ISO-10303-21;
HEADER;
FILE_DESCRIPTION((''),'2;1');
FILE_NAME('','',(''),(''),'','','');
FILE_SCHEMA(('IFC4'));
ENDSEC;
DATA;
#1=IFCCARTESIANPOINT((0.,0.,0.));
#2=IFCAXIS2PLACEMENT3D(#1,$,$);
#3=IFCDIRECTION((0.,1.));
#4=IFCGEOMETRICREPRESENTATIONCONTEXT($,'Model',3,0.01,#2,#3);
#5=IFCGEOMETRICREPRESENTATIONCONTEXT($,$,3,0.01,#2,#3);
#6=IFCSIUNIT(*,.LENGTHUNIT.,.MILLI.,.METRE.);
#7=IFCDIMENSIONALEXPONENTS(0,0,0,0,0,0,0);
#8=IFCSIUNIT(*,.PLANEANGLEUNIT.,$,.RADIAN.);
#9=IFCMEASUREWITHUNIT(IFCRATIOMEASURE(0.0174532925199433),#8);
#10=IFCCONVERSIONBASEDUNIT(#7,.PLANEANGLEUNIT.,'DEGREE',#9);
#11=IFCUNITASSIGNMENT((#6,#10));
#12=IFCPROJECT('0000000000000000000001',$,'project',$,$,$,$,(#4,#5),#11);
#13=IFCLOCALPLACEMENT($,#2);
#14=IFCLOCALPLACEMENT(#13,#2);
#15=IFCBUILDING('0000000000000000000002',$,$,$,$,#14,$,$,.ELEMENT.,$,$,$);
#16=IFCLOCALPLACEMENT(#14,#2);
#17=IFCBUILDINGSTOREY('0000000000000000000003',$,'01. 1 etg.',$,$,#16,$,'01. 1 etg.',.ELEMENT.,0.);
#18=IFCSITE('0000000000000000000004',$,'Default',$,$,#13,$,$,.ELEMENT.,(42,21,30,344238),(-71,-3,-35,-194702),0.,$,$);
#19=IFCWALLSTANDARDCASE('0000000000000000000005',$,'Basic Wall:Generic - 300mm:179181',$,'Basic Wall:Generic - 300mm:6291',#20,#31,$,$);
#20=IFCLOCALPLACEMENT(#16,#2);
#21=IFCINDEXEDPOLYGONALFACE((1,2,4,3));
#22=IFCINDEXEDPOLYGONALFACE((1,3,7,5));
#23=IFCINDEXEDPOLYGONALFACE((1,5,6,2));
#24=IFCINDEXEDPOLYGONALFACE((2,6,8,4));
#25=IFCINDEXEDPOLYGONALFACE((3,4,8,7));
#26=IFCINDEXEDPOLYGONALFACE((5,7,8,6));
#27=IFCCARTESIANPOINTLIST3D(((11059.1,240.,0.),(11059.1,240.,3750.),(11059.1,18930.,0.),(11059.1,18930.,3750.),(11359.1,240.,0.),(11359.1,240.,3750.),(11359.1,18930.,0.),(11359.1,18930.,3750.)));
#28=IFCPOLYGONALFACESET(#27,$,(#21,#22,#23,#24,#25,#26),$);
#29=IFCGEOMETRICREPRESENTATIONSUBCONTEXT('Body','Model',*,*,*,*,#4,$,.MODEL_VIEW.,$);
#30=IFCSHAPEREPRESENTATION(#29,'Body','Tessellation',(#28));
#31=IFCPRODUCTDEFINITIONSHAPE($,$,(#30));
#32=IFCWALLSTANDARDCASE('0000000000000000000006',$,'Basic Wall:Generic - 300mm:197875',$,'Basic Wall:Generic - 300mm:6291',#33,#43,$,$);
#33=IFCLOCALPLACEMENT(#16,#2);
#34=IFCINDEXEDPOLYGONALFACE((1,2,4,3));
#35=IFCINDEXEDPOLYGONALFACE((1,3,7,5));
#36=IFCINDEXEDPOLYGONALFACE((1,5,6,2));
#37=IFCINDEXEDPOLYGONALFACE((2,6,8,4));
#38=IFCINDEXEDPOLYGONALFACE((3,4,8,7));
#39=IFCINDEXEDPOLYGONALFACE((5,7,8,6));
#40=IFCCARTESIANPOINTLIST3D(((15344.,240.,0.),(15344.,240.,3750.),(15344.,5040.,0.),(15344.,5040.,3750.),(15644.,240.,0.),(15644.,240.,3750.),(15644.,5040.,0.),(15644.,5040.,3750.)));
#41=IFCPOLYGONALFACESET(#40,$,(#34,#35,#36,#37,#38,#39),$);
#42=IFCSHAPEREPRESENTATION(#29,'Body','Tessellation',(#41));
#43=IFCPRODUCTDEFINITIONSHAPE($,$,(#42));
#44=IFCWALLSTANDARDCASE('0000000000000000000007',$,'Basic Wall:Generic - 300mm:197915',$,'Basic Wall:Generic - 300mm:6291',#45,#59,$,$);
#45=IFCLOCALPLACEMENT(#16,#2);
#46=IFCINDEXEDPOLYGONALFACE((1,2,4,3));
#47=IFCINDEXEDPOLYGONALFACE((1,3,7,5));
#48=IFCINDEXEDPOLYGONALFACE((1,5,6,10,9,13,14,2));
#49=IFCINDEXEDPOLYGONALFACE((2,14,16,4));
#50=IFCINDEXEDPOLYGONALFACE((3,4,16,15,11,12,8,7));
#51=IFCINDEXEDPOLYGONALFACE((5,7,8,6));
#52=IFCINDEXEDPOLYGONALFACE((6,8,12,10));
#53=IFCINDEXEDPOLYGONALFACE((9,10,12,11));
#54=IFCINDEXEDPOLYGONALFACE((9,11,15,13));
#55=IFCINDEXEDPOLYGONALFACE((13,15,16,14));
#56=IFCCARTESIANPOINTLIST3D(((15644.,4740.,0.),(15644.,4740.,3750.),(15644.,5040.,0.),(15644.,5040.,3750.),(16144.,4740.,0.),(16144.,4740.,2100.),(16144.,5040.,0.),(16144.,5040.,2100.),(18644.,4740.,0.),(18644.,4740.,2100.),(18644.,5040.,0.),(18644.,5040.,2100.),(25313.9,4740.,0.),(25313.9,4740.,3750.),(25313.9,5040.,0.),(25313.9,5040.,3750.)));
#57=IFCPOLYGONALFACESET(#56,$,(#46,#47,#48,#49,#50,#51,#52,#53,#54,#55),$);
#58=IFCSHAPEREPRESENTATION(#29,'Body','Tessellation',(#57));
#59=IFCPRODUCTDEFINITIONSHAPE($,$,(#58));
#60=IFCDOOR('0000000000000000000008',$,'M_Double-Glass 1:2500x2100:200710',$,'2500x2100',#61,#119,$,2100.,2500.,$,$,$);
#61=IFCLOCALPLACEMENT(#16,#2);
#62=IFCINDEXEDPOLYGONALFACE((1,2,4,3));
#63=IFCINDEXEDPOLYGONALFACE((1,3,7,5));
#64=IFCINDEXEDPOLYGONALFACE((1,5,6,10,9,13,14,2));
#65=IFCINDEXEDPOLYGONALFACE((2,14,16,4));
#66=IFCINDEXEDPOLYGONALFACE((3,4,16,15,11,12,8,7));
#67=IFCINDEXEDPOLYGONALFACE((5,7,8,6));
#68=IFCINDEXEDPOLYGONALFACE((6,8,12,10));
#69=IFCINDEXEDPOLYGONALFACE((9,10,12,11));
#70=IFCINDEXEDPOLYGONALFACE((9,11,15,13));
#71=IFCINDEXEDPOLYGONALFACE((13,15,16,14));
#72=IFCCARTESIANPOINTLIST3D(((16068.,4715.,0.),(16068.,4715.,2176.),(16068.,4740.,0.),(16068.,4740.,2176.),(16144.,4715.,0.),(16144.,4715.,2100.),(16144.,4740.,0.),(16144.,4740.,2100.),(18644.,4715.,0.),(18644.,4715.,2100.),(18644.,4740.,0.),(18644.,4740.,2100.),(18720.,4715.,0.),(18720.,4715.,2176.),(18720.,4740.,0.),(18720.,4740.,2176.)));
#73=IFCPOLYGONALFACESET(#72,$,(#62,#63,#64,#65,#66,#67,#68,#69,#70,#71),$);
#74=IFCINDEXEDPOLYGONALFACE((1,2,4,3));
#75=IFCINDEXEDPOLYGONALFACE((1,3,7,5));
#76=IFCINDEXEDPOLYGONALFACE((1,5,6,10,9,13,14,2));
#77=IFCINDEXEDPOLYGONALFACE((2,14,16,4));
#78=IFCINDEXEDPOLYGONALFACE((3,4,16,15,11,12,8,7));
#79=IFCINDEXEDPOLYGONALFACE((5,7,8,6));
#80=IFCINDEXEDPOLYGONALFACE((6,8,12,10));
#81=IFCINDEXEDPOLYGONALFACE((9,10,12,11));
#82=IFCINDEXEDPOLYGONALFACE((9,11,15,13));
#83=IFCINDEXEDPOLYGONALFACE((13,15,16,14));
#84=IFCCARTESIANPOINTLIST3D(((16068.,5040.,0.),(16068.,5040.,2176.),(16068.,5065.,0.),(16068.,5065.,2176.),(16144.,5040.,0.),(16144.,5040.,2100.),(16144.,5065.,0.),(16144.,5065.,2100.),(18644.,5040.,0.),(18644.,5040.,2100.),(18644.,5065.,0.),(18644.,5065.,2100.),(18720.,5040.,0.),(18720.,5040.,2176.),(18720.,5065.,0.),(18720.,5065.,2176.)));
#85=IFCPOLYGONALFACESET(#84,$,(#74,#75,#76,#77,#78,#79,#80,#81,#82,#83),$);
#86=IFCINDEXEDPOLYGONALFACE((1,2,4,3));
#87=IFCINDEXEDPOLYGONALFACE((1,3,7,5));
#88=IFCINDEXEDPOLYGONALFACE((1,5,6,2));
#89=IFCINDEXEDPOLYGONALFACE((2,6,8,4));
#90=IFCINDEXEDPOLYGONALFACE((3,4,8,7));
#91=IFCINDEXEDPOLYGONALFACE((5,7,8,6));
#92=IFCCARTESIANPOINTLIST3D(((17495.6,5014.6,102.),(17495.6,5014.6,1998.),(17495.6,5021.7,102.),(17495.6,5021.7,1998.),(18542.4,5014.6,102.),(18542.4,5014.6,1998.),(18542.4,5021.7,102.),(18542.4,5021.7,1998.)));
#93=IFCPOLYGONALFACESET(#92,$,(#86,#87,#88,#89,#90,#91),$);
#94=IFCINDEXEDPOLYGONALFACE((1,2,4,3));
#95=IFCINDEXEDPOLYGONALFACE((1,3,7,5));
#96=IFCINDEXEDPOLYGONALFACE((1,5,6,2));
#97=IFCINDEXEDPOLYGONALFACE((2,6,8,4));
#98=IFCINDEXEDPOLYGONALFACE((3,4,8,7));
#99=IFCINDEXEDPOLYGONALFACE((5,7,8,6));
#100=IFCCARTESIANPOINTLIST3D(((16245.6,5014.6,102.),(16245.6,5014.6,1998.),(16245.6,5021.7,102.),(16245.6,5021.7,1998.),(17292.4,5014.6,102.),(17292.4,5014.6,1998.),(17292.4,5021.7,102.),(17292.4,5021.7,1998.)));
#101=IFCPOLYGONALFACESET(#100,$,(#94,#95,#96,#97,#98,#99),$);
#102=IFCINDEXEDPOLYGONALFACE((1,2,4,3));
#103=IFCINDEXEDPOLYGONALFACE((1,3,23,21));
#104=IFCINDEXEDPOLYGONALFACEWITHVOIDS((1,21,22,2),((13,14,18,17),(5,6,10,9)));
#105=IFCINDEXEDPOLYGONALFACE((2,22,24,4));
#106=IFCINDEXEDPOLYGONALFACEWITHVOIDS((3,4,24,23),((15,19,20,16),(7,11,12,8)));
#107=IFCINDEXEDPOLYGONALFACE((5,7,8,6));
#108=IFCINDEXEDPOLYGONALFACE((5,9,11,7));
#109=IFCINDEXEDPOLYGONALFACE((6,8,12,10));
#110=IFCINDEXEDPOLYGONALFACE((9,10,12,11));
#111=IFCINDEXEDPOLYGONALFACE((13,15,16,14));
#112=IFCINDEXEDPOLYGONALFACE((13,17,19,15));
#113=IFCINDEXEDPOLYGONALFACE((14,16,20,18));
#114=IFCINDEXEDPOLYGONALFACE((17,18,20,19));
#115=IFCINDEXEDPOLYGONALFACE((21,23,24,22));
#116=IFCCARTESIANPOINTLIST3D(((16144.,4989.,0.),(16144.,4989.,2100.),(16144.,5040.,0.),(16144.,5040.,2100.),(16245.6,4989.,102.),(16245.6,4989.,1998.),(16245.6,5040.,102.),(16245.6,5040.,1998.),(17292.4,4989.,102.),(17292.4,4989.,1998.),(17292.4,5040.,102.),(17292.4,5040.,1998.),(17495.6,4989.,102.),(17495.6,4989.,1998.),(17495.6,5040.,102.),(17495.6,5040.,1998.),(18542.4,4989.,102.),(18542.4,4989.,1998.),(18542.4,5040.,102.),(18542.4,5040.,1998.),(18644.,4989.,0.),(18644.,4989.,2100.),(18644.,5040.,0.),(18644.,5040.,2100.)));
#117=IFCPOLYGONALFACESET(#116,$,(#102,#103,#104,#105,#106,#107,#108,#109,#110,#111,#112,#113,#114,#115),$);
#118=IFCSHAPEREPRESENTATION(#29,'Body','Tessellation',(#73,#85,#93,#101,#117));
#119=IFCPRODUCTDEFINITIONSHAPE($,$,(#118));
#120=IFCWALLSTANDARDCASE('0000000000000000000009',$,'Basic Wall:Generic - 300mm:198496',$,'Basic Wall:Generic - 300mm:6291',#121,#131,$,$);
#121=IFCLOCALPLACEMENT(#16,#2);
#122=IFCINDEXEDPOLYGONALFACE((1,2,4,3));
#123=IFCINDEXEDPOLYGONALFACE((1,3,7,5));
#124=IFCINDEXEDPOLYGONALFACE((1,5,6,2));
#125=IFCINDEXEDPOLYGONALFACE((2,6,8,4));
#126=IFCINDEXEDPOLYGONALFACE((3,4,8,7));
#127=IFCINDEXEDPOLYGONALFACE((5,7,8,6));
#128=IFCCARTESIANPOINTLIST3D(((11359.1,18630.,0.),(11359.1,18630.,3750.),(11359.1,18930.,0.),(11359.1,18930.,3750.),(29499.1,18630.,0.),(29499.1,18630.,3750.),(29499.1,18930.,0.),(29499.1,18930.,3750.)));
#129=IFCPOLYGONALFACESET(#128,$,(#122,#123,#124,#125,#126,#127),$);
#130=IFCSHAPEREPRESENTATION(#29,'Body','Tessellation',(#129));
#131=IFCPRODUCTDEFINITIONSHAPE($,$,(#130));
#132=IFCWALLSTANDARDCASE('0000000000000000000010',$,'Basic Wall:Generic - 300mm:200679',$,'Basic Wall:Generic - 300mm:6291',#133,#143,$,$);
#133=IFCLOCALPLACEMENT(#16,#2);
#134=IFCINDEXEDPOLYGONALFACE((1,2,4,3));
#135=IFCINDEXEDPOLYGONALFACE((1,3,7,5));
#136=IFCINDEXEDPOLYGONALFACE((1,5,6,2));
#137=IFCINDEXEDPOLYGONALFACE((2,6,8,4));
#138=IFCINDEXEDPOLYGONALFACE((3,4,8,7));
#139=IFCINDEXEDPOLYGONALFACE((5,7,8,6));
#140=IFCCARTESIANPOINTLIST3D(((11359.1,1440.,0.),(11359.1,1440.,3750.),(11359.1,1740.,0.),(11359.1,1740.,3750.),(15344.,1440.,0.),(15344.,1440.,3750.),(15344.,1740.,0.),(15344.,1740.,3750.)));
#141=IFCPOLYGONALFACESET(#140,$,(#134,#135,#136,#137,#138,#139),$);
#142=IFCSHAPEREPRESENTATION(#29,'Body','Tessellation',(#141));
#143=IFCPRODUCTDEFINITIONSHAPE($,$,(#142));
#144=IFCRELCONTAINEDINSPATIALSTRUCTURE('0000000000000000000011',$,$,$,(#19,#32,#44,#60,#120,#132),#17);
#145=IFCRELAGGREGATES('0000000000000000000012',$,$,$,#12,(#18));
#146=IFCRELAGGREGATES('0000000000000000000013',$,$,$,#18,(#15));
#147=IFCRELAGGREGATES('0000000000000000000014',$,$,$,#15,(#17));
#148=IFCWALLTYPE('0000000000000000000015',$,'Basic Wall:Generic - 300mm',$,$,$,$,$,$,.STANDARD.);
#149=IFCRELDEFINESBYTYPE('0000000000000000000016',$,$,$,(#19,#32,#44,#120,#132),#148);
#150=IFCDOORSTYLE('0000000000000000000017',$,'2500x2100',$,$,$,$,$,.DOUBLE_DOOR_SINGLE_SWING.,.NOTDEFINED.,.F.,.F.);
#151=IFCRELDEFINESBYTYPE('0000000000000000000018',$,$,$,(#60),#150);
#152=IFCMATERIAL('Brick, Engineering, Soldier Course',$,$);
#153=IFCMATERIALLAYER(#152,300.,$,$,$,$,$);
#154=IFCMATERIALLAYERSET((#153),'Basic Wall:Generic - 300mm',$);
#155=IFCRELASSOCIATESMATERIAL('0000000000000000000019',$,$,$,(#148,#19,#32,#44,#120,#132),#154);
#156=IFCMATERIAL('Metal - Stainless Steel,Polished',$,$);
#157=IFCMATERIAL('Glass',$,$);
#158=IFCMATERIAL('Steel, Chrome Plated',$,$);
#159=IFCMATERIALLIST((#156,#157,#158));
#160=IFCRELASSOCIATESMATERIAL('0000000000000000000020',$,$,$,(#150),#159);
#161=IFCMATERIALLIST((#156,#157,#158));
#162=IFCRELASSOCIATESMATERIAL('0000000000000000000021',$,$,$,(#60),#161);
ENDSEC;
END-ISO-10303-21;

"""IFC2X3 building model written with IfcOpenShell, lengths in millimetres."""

from ifc_helpers import new_model, entity, si_unit, converted_unit, direction, frame, frame_2d, origin, place, context, subcontext, project, spatial, polyline, rectangle, outline, extrude, clip, halfspace, source, transform, mapped, material, material_list, layer, layer_set, layer_usage, type_object, type_shapes, element, fill, save


model = new_model("IFC2X3")

# Units and contexts
model_context = context("Model", 3, precision=0.01, world=origin(), true_north=direction((0.0, 1.0)))
context_of_model = context(None, 3, precision=0.01, world=origin(), true_north=direction((0.0, 1.0)))
body_context = subcontext(model_context, "Body", "Model", "MODEL_VIEW")
ifc_project = project(units=[si_unit("LENGTHUNIT", "METRE", prefix="MILLI"), converted_unit("PLANEANGLEUNIT", "DEGREE", entity("IfcRatioMeasure", 0.0174532925199433), si_unit("PLANEANGLEUNIT", "RADIAN"), dimensions=[0, 0, 0, 0, 0, 0, 0])], contexts=[model_context, context_of_model])

# Site, building, storey
site_placement = place(None, origin())
site = spatial("IfcSite", under=ifc_project, at=site_placement, Name="Default", CompositionType="ELEMENT", RefLatitude=(42, 21, 30, 344238), RefLongitude=(-71, -3, -35, -194702), RefElevation=0.0)
building_placement = place(site_placement, origin())
building = spatial("IfcBuilding", under=site, at=building_placement, CompositionType="ELEMENT")
storey_placement = place(building_placement, origin())
storey = spatial("IfcBuildingStorey", under=building, at=storey_placement, Name="01. 1 etg.", LongName="01. 1 etg.", CompositionType="ELEMENT", Elevation=0.0)

# Shared definitions
ifc_material_1 = material(Name="Brick, Engineering, Soldier Course")
ifc_layer_1 = layer(ifc_material_1, 300.0)
ifc_layer_set_1 = layer_set([ifc_layer_1], Name="Basic Wall:Generic - 300mm")
wall_type_1 = type_object("IfcWallType", Name="Basic Wall:Generic - 300mm", PredefinedType="STANDARD", material=ifc_layer_set_1)
ifc_material_2 = material(Name="Glass")

# Shared definitions
ifc_material_3 = material(Name="Metal - Stainless Steel,Polished")
ifc_material_4 = material(Name="Steel, Chrome Plated")

# Walls
ifc_layer_usage_1 = layer_usage(ifc_layer_set_1, "AXIS2", "NEGATIVE", 150.0)
wall_1_placement = place(storey_placement, frame((11209.1, 240.0, 0.0), z_axis=(0.0, 0.0, 1.0), x_axis=(0.0, 1.0, 0.0)))
element("IfcWallStandardCase", 1, at=wall_1_placement, inside=storey, type_object=wall_type_1, material=ifc_layer_usage_1, Name="Basic Wall:Generic - 300mm:179181", ObjectType="Basic Wall:Generic - 300mm:6291", context=body_context, shape_type="Clipping", body=[
    clip(extrude(rectangle(XDim=18690.0, YDim=300.0, at=frame_2d((9345.0, 0.0), x_axis=(-1.0, 0.0))), origin(), (0.0, 0.0, 1.0), 3750.0), halfspace(origin(), True)),
])
ifc_layer_usage_2 = layer_usage(ifc_layer_set_1, "AXIS2", "NEGATIVE", 150.0)
wall_2_placement = place(storey_placement, frame((15494.0, 240.0, 0.0), z_axis=(0.0, 0.0, 1.0), x_axis=(0.0, 1.0, 0.0)))
element("IfcWallStandardCase", 2, at=wall_2_placement, inside=storey, type_object=wall_type_1, material=ifc_layer_usage_2, Name="Basic Wall:Generic - 300mm:197875", ObjectType="Basic Wall:Generic - 300mm:6291", context=body_context, shape_type="SweptSolid", body=[
    extrude(rectangle(XDim=4800.0, YDim=300.0, at=frame_2d((2400.0, 0.0), x_axis=(-1.0, 0.0))), origin(), (0.0, 0.0, 1.0), 3750.0),
])

# Wall, opening, door
ifc_layer_usage_3 = layer_usage(ifc_layer_set_1, "AXIS2", "NEGATIVE", 150.0)
wall_3_placement = place(storey_placement, frame((15644.0, 4890.0, 0.0)))
wall_3 = element("IfcWallStandardCase", 3, at=wall_3_placement, inside=storey, type_object=wall_type_1, material=ifc_layer_usage_3, Name="Basic Wall:Generic - 300mm:197915", ObjectType="Basic Wall:Generic - 300mm:6291", context=body_context, shape_type="SweptSolid", body=[
    extrude(rectangle(XDim=9669.9, YDim=300.0, at=frame_2d((4834.9, 0.0), x_axis=(-1.0, 0.0))), origin(), (0.0, 0.0, 1.0), 3750.0),
])
opening_1_placement = place(wall_3_placement, frame((500.0, -150.0, 0.0)))
opening_1 = element("IfcOpeningElement", 4, at=opening_1_placement, cuts=wall_3, ObjectType="Opening", context=body_context, shape_type="SweptSolid", body=[
    extrude(rectangle(XDim=2500.0, YDim=2100.0, at=frame_2d((1050.0, 1250.0), x_axis=(0.0, 1.0))), frame((0.0, 0.0, 0.0), z_axis=(0.0, 1.0, 0.0), x_axis=(0.0, 0.0, 1.0)), (0.0, 0.0, 1.0), 300.0),
])
ifc_material_list_1 = material_list([ifc_material_3, ifc_material_2, ifc_material_4])
ifc_material_list_2 = material_list([ifc_material_3, ifc_material_2, ifc_material_4])
door_style_1 = type_object("IfcDoorStyle", Name="2500x2100", ConstructionType="NOTDEFINED", OperationType="DOUBLE_DOOR_SINGLE_SWING", ParameterTakesPrecedence=False, Sizeable=False, material=ifc_material_list_2)
shared_shape_1 = source(origin(), body_context, "Body", "SweptSolid", [
    extrude(outline(polyline([(-1326.0, -1069.0), (-1250.0, -1069.0), (-1250.0, 1031.0), (1250.0, 1031.0), (1250.0, -1069.0), (1326.0, -1069.0), (1326.0, 1107.0), (-1326.0, 1107.0), (-1326.0, -1069.0)])), frame((1250.0, -25.0, 1069.0), z_axis=(0.0, 1.0, 0.0), x_axis=(-1.0, 0.0, 0.0)), (0.0, 0.0, 1.0), 25.0),
    extrude(outline(polyline([(-1250.0, -1031.0), (-1250.0, 1069.0), (-1326.0, 1069.0), (-1326.0, -1107.0), (1326.0, -1107.0), (1326.0, 1069.0), (1250.0, 1069.0), (1250.0, -1031.0), (-1250.0, -1031.0)])), frame((1250.0, 300.0, 1069.0), z_axis=(0.0, -1.0, 0.0), x_axis=(-1.0, 0.0, 0.0)), (0.0, 0.0, -1.0), 25.0),
    extrude(rectangle(XDim=7.1, YDim=1046.8, at=frame_2d((0.0, 0.0), x_axis=(1.0, 0.0))), frame((1875.0, 278.2, 102.0), z_axis=(0.0, 0.0, 1.0), x_axis=(0.0, 1.0, 0.0)), (0.0, 0.0, 1.0), 1896.0),
    extrude(rectangle(XDim=7.1, YDim=1046.8, at=frame_2d((0.0, 0.0), x_axis=(1.0, 0.0))), frame((625.0, 278.2, 102.0), z_axis=(0.0, 0.0, 1.0), x_axis=(0.0, 1.0, 0.0)), (0.0, 0.0, 1.0), 1896.0),
    extrude(outline(polyline([(-1050.0, -1250.0), (1050.0, -1250.0), (1050.0, 1250.0), (-1050.0, 1250.0), (-1050.0, -1250.0)]), holes=[polyline([(-948.0, 101.6), (-948.0, 1148.4), (948.0, 1148.4), (948.0, 101.6), (-948.0, 101.6)]), polyline([(-948.0, -1148.4), (-948.0, -101.6), (948.0, -101.6), (948.0, -1148.4), (-948.0, -1148.4)])]), frame((1250.0, 249.0, 1050.0), z_axis=(0.0, 1.0, 0.0), x_axis=(0.0, 0.0, -1.0)), (0.0, 0.0, 1.0), 51.0),
])
type_shapes(door_style_1, [shared_shape_1])
door_1_placement = place(opening_1_placement, origin())
door_1 = element("IfcDoor", 5, at=door_1_placement, inside=storey, type_object=door_style_1, material=ifc_material_list_1, Name="M_Double-Glass 1:2500x2100:200710", ObjectType="2500x2100", OverallHeight=2100.0, OverallWidth=2500.0, context=body_context, shape_type="MappedRepresentation", body=[
    mapped(shared_shape_1, transform((0.0, 0.0, 0.0), scale=1.0)),
])
fill(opening_1, door_1)

# Walls
ifc_layer_usage_4 = layer_usage(ifc_layer_set_1, "AXIS2", "NEGATIVE", 150.0)
wall_4_placement = place(storey_placement, frame((11359.1, 18780.0, 0.0)))
element("IfcWallStandardCase", 6, at=wall_4_placement, inside=storey, type_object=wall_type_1, material=ifc_layer_usage_4, Name="Basic Wall:Generic - 300mm:198496", ObjectType="Basic Wall:Generic - 300mm:6291", context=body_context, shape_type="SweptSolid", body=[
    extrude(rectangle(XDim=18140.0, YDim=300.0, at=frame_2d((9070.0, 0.0), x_axis=(-1.0, 0.0))), origin(), (0.0, 0.0, 1.0), 3750.0),
])
ifc_layer_usage_5 = layer_usage(ifc_layer_set_1, "AXIS2", "NEGATIVE", 150.0)
wall_5_placement = place(storey_placement, frame((15344.0, 1590.0, 0.0), z_axis=(0.0, 0.0, 1.0), x_axis=(-1.0, 0.0, 0.0)))
element("IfcWallStandardCase", 7, at=wall_5_placement, inside=storey, type_object=wall_type_1, material=ifc_layer_usage_5, Name="Basic Wall:Generic - 300mm:200679", ObjectType="Basic Wall:Generic - 300mm:6291", context=body_context, shape_type="SweptSolid", body=[
    extrude(rectangle(XDim=3984.9, YDim=300.0, at=frame_2d((1992.4, 0.0), x_axis=(-1.0, 0.0))), origin(), (0.0, 0.0, 1.0), 3750.0),
])

save(model, "model.ifc")
